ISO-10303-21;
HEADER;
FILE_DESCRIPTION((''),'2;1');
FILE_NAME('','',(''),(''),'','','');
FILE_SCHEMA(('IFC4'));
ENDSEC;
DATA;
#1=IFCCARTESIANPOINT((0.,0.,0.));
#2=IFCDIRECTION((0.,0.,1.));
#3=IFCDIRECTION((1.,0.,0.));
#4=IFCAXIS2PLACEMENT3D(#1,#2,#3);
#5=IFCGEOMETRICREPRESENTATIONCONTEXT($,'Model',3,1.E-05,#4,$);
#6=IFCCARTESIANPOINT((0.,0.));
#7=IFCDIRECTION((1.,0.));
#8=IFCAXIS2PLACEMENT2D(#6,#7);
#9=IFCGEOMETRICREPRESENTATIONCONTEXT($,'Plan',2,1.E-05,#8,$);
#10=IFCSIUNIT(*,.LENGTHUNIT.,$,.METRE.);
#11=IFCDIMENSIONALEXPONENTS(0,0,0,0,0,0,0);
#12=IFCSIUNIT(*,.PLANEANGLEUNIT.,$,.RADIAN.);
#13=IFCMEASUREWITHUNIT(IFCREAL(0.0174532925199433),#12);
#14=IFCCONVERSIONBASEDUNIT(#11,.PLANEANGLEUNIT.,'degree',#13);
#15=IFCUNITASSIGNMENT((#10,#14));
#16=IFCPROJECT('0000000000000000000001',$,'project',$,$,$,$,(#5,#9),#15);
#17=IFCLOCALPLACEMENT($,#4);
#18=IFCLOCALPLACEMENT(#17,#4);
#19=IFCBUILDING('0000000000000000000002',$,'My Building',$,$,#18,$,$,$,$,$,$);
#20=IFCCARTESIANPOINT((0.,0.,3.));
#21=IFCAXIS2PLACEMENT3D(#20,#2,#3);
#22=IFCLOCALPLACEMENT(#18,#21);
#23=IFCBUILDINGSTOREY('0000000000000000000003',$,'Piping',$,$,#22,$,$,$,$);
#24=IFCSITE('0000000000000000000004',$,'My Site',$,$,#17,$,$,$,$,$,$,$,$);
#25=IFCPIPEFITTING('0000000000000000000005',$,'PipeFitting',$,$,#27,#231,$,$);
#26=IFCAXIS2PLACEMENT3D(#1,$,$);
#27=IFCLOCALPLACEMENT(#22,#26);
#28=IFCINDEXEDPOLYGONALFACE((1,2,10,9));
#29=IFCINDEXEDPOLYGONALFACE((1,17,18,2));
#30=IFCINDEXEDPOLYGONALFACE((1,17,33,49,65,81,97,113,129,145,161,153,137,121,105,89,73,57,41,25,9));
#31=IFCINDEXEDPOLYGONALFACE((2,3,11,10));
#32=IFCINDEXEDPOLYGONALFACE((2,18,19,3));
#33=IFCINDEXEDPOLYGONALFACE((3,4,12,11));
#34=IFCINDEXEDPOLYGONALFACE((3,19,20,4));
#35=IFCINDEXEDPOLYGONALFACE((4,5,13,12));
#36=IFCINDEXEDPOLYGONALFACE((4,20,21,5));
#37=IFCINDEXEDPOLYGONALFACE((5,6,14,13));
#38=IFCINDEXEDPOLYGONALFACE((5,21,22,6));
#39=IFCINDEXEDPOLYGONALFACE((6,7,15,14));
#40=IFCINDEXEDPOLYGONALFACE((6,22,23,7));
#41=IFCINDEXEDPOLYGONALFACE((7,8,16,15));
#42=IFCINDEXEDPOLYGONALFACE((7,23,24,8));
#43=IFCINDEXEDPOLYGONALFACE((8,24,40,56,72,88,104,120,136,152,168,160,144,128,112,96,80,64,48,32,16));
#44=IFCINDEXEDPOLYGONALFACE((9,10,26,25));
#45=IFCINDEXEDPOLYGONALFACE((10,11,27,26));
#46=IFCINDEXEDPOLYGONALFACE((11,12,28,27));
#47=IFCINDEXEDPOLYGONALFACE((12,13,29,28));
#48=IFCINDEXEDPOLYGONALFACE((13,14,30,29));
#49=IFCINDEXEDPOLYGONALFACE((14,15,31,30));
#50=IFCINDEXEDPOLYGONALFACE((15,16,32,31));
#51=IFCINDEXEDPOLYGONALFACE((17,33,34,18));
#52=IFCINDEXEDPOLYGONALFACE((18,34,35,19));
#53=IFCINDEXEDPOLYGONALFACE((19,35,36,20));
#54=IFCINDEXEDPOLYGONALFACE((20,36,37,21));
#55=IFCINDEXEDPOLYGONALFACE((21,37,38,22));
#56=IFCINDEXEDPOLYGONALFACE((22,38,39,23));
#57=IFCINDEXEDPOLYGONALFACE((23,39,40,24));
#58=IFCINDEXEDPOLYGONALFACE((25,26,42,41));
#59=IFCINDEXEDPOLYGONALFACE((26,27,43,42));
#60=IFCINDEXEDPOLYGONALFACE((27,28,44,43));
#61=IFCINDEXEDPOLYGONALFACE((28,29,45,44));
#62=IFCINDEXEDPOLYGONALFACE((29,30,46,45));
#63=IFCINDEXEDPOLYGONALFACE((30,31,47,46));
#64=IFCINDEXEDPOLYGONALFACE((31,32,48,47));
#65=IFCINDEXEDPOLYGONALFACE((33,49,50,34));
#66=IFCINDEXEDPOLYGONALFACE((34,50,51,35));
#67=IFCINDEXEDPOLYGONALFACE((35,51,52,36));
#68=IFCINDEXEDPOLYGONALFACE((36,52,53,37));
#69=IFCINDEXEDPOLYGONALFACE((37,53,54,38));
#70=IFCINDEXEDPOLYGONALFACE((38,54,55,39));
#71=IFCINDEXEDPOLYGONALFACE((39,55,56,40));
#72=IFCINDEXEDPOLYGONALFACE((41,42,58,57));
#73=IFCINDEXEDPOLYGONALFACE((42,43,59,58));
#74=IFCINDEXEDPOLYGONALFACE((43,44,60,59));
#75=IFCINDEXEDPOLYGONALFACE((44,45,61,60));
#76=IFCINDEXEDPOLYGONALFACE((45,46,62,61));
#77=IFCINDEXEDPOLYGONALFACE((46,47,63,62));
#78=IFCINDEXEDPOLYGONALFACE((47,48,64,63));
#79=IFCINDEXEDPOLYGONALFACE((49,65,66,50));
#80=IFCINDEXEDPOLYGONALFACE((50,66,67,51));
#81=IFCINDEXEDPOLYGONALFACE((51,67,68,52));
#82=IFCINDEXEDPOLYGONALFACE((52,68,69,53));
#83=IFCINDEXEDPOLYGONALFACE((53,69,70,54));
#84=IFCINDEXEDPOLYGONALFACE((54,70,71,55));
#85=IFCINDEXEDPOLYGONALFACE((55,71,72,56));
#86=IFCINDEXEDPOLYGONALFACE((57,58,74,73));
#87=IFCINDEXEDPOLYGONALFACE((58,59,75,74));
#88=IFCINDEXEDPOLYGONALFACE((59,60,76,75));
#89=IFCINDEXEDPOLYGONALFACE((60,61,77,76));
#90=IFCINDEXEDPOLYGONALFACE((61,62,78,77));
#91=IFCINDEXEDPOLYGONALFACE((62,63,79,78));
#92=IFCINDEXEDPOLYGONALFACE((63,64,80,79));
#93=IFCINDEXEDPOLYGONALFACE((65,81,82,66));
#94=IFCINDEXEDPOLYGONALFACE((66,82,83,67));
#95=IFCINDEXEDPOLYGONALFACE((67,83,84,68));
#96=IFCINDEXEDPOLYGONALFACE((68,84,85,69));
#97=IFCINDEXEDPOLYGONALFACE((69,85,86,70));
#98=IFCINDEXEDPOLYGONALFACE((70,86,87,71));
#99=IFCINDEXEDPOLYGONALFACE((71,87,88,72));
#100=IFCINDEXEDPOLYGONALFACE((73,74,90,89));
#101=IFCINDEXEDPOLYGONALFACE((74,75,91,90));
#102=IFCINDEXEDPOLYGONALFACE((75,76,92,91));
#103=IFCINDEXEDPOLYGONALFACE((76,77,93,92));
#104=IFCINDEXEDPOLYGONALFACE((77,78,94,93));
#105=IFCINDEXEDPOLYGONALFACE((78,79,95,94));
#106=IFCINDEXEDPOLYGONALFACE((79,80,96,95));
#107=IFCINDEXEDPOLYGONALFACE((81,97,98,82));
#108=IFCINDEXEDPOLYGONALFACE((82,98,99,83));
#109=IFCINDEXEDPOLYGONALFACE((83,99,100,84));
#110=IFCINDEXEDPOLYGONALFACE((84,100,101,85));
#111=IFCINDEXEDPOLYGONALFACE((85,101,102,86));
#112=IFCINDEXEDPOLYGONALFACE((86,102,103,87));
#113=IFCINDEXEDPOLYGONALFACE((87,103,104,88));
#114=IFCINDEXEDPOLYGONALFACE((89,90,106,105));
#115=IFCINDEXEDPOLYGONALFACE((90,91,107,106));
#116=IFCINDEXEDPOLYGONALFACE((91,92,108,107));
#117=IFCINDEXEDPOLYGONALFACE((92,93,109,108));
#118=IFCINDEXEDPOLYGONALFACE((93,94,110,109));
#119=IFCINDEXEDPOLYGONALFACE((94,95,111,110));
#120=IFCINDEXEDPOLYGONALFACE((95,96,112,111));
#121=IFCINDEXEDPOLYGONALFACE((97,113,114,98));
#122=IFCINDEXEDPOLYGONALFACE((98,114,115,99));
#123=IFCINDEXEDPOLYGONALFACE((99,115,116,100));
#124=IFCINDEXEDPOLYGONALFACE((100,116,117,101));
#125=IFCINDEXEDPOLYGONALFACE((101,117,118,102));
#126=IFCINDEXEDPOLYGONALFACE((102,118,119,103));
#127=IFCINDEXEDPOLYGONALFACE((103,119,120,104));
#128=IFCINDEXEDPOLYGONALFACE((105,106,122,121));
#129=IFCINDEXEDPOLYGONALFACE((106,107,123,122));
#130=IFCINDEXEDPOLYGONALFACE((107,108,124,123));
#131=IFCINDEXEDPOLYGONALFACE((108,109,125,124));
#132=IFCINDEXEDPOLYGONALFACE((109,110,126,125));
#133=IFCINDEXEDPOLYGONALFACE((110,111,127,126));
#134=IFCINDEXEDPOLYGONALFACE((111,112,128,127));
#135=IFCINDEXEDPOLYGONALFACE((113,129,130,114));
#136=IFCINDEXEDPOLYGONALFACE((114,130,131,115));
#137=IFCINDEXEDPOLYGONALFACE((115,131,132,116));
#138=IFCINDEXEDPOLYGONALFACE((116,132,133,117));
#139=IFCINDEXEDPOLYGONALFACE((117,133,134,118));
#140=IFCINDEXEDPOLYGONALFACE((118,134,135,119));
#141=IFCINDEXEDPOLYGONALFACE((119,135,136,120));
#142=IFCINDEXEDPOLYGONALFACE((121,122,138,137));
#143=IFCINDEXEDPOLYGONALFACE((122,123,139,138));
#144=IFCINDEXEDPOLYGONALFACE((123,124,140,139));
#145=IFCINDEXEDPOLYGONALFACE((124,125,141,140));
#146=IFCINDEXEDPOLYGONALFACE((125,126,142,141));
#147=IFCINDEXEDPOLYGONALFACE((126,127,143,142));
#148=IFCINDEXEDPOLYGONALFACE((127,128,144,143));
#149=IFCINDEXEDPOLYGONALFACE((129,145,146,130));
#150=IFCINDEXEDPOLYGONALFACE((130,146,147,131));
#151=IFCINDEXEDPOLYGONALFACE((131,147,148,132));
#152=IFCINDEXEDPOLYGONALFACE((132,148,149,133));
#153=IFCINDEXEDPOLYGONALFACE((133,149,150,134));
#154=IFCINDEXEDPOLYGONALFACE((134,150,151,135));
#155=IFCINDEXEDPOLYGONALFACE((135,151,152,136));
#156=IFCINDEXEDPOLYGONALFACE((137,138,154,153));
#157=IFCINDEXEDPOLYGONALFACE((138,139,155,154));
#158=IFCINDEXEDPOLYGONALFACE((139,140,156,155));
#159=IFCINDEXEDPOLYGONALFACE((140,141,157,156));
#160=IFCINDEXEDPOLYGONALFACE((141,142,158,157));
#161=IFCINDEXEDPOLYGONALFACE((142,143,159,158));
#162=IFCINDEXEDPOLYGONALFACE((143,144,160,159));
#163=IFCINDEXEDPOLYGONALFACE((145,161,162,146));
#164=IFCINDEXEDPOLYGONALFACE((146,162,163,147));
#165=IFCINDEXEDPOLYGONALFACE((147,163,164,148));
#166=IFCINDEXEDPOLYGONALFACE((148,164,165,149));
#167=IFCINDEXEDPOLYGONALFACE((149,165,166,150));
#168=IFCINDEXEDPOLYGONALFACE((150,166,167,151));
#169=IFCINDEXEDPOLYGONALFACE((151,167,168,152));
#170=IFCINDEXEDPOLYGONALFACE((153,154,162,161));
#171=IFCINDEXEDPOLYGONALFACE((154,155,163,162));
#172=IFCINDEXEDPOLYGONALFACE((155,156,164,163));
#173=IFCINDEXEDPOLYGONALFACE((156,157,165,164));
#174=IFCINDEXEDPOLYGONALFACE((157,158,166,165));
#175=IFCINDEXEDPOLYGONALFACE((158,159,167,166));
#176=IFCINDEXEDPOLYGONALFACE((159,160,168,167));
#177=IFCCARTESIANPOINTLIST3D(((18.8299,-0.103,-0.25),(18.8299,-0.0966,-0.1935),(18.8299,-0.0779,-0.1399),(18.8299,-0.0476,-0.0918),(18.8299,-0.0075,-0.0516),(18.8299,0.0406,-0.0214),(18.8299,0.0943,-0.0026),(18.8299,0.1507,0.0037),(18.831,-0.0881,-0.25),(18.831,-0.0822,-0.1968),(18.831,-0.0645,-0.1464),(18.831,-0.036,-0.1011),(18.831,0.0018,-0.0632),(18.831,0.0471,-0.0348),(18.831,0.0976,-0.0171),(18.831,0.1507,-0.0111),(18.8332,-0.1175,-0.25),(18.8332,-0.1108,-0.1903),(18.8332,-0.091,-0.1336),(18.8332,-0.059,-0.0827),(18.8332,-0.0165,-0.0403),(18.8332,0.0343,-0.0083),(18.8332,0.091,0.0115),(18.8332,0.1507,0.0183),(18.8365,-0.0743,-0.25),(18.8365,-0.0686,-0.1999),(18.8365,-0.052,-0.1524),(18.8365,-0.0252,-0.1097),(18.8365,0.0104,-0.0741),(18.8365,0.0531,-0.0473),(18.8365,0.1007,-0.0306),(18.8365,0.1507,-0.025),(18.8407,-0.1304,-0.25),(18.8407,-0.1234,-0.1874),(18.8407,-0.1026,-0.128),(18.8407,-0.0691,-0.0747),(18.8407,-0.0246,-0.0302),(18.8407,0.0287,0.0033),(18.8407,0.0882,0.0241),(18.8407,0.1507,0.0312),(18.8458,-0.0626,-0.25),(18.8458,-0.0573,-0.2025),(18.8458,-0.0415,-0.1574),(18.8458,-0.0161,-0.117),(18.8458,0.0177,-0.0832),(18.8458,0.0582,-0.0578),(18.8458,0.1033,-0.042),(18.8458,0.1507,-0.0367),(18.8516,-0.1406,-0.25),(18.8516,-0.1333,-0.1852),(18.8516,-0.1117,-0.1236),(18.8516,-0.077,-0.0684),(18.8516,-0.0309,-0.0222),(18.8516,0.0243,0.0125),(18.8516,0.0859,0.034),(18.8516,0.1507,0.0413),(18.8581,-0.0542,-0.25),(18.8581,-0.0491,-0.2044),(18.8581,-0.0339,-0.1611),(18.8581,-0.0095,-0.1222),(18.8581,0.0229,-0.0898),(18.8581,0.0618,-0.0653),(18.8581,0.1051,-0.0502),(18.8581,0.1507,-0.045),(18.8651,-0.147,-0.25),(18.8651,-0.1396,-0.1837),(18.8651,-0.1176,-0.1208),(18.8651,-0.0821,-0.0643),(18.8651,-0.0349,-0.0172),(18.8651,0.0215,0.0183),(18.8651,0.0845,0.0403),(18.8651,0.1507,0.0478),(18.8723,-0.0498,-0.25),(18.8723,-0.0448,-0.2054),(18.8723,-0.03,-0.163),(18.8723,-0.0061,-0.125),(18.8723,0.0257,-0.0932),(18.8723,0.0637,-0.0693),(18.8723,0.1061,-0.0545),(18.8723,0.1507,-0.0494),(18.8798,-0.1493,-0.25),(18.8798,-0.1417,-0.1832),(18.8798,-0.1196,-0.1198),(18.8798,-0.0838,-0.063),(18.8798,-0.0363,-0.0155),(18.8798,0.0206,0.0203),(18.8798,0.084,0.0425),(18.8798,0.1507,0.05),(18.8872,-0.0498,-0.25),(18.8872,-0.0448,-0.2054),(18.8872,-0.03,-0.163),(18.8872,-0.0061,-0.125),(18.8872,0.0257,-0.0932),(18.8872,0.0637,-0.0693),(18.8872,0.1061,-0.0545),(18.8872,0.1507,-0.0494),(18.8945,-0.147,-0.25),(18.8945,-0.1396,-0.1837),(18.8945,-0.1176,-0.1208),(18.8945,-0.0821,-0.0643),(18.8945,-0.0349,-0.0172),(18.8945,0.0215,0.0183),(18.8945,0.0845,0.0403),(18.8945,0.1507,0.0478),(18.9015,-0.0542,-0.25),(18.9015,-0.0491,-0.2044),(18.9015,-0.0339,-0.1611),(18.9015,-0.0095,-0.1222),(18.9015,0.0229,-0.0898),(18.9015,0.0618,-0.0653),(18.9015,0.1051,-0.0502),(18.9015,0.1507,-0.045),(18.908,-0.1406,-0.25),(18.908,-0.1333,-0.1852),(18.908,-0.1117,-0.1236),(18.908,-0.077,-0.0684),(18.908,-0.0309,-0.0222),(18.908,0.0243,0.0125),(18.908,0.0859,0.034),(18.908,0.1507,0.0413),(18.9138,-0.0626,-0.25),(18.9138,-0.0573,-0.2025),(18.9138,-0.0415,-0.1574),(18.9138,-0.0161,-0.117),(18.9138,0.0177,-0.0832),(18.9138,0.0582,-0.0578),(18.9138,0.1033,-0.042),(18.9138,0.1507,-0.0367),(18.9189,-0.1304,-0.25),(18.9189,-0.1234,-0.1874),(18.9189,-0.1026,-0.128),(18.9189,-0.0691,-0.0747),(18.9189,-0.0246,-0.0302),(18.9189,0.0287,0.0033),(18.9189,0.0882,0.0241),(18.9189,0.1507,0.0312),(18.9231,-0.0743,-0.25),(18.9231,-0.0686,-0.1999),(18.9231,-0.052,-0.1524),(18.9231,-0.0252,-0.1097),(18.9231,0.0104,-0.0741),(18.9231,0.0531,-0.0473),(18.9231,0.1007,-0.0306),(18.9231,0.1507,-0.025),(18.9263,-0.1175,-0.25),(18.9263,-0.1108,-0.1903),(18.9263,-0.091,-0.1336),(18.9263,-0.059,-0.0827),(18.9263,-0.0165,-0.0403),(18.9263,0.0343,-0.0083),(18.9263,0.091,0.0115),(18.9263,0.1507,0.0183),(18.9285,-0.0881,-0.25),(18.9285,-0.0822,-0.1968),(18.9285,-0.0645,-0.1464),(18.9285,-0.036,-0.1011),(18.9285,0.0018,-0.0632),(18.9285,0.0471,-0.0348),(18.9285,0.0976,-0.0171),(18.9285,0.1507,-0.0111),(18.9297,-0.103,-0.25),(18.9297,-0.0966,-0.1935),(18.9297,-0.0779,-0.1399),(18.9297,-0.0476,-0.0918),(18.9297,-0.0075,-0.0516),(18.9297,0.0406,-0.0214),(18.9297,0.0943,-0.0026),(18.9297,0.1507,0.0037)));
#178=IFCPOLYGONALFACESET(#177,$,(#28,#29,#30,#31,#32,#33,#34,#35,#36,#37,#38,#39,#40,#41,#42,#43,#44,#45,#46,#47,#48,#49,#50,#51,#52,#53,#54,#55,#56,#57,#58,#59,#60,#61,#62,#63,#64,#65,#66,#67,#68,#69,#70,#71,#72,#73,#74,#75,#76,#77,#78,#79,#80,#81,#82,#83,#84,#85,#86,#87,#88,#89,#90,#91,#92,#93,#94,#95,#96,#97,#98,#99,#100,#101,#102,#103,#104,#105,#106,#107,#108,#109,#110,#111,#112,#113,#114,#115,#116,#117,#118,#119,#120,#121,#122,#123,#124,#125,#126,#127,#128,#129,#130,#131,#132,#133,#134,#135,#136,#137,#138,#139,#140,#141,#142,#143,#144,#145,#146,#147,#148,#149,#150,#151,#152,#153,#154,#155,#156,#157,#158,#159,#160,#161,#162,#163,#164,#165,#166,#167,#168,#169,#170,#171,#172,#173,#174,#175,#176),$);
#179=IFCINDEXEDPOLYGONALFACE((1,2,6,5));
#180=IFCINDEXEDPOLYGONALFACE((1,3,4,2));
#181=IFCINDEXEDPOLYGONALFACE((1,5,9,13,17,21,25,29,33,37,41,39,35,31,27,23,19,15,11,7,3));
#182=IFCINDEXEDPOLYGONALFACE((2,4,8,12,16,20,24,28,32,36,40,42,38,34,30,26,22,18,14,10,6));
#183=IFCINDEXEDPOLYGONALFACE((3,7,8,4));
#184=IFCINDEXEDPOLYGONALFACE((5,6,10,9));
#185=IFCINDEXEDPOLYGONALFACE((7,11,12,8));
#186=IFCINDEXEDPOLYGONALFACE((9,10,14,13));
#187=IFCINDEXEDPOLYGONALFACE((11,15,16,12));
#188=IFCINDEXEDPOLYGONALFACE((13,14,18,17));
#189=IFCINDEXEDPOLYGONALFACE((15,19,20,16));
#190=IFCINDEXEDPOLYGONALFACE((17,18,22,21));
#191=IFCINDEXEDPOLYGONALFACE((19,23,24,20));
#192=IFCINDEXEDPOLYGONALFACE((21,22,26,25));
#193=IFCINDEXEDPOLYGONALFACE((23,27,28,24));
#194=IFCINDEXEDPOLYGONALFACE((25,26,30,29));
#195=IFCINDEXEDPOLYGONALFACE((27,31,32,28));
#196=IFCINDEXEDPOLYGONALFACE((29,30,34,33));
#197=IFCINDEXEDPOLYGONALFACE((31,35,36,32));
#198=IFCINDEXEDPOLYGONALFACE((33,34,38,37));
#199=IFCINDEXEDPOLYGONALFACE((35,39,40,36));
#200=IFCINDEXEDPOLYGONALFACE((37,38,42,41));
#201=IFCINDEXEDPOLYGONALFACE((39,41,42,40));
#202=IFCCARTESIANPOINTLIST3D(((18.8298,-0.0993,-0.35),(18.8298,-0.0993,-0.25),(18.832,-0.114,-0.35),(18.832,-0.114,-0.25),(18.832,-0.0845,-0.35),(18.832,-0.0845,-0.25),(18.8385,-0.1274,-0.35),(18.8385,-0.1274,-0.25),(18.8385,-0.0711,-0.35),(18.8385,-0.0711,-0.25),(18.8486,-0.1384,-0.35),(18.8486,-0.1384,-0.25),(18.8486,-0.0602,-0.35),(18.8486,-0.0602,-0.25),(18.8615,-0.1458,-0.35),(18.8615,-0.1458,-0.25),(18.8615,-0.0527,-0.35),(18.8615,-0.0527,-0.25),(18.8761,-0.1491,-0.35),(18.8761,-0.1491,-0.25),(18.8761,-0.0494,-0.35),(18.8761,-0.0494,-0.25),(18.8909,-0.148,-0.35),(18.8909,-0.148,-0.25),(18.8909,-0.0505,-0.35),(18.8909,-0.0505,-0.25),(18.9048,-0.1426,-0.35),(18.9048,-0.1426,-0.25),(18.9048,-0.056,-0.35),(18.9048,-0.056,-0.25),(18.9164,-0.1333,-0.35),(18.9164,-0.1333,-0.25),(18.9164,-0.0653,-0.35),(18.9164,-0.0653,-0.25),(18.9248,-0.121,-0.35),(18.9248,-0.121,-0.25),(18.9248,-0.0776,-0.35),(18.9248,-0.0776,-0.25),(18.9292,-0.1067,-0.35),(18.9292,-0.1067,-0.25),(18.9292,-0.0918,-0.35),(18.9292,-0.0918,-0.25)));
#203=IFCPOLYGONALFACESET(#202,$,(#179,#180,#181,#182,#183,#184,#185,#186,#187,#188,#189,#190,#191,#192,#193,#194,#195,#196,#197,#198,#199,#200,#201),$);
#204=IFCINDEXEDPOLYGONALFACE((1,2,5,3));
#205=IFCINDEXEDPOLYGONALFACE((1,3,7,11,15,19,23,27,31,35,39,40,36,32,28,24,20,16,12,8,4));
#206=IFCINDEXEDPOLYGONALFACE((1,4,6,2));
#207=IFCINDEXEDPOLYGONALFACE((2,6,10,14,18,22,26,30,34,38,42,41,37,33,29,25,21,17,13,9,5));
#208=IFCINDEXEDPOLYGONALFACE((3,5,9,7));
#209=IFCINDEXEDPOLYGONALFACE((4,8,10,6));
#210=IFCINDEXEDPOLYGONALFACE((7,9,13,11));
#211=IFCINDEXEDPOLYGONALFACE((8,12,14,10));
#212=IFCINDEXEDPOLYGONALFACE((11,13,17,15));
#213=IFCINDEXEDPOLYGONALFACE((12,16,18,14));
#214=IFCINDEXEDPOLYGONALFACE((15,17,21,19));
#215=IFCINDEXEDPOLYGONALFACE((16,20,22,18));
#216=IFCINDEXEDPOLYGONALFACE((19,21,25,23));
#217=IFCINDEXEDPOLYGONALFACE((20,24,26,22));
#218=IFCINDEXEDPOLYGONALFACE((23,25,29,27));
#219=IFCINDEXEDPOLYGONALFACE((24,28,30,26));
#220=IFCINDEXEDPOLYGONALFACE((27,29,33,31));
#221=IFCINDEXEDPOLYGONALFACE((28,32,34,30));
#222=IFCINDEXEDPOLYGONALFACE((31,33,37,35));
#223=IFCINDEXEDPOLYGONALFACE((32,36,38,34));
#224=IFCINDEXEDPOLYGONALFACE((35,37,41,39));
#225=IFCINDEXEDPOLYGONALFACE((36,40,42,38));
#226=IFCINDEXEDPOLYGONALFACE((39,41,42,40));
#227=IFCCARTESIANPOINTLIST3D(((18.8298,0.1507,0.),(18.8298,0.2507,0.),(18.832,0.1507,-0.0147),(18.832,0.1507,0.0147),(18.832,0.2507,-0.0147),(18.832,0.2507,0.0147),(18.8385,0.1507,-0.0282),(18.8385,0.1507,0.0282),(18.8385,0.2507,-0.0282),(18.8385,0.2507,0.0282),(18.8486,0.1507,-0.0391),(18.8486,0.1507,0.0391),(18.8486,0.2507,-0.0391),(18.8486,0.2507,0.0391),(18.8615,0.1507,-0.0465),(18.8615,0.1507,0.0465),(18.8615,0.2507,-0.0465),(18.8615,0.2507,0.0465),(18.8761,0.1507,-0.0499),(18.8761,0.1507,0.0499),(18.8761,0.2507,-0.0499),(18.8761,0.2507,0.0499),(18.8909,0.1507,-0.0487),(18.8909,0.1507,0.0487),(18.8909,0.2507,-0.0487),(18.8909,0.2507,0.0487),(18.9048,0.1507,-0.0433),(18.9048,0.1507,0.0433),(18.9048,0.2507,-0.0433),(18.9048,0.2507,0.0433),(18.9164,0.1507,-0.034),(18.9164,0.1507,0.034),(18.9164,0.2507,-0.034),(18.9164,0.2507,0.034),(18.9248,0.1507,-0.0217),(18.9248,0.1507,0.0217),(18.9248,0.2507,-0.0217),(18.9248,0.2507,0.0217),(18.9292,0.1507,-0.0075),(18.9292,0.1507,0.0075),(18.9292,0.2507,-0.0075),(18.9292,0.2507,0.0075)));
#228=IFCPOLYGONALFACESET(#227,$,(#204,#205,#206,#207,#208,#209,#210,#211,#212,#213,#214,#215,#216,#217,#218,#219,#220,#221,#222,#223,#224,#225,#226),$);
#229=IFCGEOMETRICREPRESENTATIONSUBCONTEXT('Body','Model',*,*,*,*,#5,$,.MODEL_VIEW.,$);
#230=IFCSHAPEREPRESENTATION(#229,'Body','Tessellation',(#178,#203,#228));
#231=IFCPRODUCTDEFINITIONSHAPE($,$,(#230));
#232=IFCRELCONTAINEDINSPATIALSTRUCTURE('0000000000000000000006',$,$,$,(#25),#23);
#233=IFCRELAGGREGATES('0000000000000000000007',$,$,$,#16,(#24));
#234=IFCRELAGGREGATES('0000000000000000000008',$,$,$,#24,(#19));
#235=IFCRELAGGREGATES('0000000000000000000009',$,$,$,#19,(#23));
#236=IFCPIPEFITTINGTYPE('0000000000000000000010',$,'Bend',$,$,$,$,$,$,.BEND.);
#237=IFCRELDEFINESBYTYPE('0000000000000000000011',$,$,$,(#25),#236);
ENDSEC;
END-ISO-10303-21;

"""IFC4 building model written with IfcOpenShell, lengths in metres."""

from ifc_helpers import new_model, entity, si_unit, converted_unit, frame, origin_with_axes, origin_2d_with_axis, place, context, subcontext, project, spatial, circle, extrude, source, transform, mapped, type_object, type_shapes, element, save


model = new_model("IFC4")

# Units and contexts
model_context = context("Model", 3, precision=1e-05, world=origin_with_axes())
plan_context = context("Plan", 2, precision=1e-05, world=origin_2d_with_axis())
body_context = subcontext(model_context, "Body", "Model", "MODEL_VIEW")
ifc_project = project(units=[si_unit("LENGTHUNIT", "METRE"), converted_unit("PLANEANGLEUNIT", "degree", entity("IfcReal", 0.0174532925199433), si_unit("PLANEANGLEUNIT", "RADIAN"), dimensions=[0, 0, 0, 0, 0, 0, 0])], contexts=[model_context, plan_context])

# Site, building, storey
site_placement = place(None, origin_with_axes())
site = spatial("IfcSite", under=ifc_project, at=site_placement, Name="My Site")
building_placement = place(site_placement, origin_with_axes())
building = spatial("IfcBuilding", under=site, at=building_placement, Name="My Building")
storey_placement = place(building_placement, frame((0.0, 0.0, 3.0), z_axis=(0.0, 0.0, 1.0), x_axis=(1.0, 0.0, 0.0)))
storey = spatial("IfcBuildingStorey", under=building, at=storey_placement, Name="Piping")

# Pipe fitting
pipe_fitting_type_1 = type_object("IfcPipeFittingType", Name="Bend", PredefinedType="BEND")
shared_shape = source(origin_with_axes(), body_context, "Body", "SolidModel", [
    entity("IfcSweptDiskSolid", entity("IfcIndexedPolyCurve", entity("IfcCartesianPointList3D", [[0.0, 0.0, -0.1], [0.0, 0.0732, -0.2768], [0.0, 0.25, -0.35]]), [entity("IfcArcIndex", [1, 2, 3])]), 0.05),
    extrude(circle(Radius=0.05), origin_with_axes(), (0.0, 0.0, -1.0), 0.1),
    extrude(circle(Radius=0.05), frame((0.0, 0.25, -0.35), z_axis=(0.0, 1.0, 0.0), x_axis=(1.0, 0.0, 0.0)), (0.0, 0.0, 1.0), 0.1),
])
type_shapes(pipe_fitting_type_1, [shared_shape])
for number, where, z_axis, x_axis, name in (
    (1, (18.8798, -0.0993, -0.35), (0.0, 0.0, -1.0), (-1.0, 0.0, 0.0), "PipeFitting"),
):
    element("IfcPipeFitting", number, at=place(storey_placement, frame(where, z_axis=z_axis, x_axis=x_axis)), inside=storey, type_object=pipe_fitting_type_1, Name=name, context=body_context, shape_type="MappedRepresentation", body=[
        mapped(shared_shape, transform((0.0, 0.0, 0.0), x_axis=(1.0, 0.0, 0.0), y_axis=(0.0, 1.0, 0.0), z_axis=(0.0, 0.0, 1.0), scale=1.0)),
    ])

save(model, "model.ifc")
